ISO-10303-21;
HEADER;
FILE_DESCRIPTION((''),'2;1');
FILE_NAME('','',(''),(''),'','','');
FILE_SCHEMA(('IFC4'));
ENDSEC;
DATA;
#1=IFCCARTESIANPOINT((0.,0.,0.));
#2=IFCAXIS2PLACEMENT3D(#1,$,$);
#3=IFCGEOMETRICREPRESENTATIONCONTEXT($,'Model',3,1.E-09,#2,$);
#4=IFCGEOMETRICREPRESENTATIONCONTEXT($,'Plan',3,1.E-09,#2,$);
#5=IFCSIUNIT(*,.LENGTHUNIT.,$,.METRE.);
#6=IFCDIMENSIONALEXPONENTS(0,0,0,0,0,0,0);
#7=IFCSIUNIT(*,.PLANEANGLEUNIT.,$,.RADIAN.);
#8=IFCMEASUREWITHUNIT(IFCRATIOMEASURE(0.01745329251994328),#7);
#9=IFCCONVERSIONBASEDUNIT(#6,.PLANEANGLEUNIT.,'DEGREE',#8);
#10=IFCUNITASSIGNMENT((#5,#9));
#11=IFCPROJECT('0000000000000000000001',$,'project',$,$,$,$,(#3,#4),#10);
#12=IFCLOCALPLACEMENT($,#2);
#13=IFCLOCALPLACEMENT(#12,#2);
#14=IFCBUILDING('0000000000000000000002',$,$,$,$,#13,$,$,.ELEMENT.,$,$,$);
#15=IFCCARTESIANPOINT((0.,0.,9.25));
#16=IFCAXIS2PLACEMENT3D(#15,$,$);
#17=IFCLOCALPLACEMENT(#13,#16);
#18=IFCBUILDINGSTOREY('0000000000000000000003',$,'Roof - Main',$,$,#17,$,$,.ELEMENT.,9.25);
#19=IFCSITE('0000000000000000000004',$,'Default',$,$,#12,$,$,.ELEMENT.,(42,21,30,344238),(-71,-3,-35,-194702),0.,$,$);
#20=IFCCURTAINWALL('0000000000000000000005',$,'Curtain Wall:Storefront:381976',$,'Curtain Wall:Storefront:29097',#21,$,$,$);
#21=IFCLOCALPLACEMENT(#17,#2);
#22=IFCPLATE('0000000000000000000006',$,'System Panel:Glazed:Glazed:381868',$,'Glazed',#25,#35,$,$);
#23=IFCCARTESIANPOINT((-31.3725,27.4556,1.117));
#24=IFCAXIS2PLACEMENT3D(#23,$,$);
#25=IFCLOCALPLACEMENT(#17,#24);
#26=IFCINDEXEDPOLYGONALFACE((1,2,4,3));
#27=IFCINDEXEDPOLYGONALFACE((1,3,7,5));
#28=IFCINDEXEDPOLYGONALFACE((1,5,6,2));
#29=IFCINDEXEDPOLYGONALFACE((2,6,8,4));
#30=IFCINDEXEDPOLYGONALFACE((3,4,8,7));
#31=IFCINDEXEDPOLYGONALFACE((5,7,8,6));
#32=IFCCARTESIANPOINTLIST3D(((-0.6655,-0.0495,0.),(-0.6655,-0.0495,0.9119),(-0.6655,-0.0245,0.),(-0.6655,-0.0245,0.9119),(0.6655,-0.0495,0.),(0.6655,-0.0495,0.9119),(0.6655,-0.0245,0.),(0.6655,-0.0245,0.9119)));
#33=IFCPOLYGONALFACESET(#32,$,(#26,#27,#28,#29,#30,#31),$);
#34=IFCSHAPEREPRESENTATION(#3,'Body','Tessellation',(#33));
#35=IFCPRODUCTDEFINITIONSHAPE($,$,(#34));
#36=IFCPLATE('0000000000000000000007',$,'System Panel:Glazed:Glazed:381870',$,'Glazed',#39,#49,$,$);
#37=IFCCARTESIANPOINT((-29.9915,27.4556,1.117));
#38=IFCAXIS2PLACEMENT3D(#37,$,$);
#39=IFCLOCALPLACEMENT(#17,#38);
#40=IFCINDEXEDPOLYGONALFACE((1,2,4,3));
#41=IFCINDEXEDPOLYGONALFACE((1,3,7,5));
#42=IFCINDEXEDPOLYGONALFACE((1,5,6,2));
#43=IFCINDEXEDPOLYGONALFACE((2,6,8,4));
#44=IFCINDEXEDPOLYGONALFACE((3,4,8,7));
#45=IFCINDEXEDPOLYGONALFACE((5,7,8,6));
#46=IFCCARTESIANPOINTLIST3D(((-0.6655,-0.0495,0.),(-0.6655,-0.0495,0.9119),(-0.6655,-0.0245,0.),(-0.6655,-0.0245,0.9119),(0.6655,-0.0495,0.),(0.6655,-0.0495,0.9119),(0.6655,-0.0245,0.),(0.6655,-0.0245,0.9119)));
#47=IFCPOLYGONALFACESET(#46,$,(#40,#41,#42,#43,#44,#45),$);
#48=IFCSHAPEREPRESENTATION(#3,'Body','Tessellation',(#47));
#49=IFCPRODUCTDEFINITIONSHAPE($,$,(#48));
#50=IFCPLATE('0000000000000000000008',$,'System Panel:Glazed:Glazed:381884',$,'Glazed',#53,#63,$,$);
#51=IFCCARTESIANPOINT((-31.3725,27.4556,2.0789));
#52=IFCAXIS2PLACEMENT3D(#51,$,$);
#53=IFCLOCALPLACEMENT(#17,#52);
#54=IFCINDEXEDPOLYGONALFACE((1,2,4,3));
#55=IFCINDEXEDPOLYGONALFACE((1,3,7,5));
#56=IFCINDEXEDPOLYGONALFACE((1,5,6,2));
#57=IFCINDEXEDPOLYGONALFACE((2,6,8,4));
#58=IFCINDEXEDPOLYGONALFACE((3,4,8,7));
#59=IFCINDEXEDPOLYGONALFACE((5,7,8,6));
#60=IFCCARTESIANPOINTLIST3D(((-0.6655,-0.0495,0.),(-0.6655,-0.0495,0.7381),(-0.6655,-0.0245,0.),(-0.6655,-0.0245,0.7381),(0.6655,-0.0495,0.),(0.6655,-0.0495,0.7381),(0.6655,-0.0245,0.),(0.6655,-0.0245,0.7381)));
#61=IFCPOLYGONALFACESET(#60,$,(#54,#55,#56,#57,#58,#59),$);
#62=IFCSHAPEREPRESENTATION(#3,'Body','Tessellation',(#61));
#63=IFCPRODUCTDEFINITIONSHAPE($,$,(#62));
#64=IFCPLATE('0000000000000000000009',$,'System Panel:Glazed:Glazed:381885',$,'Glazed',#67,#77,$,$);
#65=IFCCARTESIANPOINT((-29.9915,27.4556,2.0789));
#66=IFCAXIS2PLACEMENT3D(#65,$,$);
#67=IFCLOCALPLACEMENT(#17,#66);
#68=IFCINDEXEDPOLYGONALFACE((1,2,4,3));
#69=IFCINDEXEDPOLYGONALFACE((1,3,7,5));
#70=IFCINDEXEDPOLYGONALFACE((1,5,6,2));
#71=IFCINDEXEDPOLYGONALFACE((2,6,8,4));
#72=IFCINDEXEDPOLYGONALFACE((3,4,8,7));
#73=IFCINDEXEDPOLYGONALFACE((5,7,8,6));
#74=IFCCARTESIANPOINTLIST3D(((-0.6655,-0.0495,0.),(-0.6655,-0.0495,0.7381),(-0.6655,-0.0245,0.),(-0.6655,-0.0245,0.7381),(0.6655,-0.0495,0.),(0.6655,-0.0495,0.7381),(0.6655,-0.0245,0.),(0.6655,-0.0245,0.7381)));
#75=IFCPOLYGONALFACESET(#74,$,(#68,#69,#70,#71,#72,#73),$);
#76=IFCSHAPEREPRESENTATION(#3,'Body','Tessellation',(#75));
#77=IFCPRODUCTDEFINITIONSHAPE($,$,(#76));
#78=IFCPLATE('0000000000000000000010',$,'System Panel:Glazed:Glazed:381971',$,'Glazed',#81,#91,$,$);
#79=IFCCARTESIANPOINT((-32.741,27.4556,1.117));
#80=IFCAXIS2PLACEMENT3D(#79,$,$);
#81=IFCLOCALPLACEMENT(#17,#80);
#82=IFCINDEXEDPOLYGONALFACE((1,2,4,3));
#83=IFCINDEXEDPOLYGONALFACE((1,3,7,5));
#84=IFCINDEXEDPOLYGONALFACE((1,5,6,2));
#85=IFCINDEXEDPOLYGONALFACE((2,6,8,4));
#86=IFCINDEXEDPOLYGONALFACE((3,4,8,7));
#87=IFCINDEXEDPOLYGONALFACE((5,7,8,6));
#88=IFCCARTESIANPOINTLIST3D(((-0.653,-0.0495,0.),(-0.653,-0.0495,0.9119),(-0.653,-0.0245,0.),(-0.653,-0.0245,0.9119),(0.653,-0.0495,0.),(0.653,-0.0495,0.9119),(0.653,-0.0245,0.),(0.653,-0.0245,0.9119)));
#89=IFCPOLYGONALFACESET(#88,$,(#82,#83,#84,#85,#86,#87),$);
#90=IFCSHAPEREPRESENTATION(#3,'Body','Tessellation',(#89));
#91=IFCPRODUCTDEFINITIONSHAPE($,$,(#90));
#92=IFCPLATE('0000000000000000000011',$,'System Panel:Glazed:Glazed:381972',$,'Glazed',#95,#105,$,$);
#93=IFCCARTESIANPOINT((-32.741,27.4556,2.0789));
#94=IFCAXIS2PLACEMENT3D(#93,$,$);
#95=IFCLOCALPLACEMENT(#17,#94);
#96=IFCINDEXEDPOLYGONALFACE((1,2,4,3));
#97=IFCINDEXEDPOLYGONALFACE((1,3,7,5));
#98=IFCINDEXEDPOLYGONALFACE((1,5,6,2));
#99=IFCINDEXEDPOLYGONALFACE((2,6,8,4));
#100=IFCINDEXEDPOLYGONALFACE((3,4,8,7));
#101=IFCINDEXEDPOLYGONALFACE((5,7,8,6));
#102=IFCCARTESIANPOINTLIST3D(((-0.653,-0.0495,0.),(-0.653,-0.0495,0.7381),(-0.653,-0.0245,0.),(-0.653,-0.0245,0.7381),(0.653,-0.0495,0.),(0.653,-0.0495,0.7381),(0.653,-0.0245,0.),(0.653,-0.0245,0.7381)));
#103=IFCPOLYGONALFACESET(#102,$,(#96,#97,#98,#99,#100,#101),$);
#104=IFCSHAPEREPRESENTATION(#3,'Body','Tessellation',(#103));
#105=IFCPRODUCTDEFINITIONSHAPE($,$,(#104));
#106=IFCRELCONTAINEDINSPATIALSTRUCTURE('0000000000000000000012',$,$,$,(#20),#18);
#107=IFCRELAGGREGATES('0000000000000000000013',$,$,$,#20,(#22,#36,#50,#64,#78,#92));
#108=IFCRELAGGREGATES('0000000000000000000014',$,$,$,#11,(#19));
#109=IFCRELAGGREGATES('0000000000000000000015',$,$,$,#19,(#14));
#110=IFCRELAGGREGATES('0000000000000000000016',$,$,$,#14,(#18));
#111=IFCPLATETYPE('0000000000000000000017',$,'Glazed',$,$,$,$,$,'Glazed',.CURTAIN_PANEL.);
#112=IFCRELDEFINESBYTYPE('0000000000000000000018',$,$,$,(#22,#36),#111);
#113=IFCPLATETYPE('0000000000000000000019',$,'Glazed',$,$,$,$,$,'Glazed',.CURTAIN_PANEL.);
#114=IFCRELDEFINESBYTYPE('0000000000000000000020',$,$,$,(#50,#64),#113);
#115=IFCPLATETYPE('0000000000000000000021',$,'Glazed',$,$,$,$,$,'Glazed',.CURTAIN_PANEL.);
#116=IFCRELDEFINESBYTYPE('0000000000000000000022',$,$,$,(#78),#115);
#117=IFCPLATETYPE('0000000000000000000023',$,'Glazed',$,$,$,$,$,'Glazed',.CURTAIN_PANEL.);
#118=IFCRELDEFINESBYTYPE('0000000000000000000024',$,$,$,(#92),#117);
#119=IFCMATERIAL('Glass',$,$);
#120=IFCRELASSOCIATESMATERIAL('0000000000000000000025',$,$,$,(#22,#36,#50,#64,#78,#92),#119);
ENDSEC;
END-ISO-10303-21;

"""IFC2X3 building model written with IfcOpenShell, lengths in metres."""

from ifc_helpers import new_model, entity, si_unit, converted_unit, frame, origin, origin_2d_with_axis, place, context, project, spatial, rectangle, extrude, source, transform, mapped, material, type_object, type_shapes, element, aggregate, save


model = new_model("IFC2X3")

# Units and contexts
model_context = context("Model", 3, precision=1e-09, world=origin())
plan_context = context("Plan", 3, precision=1e-09, world=origin())
ifc_project = project(units=[si_unit("LENGTHUNIT", "METRE"), converted_unit("PLANEANGLEUNIT", "DEGREE", entity("IfcRatioMeasure", 0.01745329251994328), si_unit("PLANEANGLEUNIT", "RADIAN"), dimensions=[0, 0, 0, 0, 0, 0, 0])], contexts=[model_context, plan_context])

# Site, building, storey
site_placement = place(None, origin())
site = spatial("IfcSite", under=ifc_project, at=site_placement, Name="Default", CompositionType="ELEMENT", RefLatitude=(42, 21, 30, 344238), RefLongitude=(-71, -3, -35, -194702), RefElevation=0.0)
building_placement = place(site_placement, origin())
building = spatial("IfcBuilding", under=site, at=building_placement, CompositionType="ELEMENT")
storey_placement = place(building_placement, frame((0.0, 0.0, 9.25)))
storey = spatial("IfcBuildingStorey", under=building, at=storey_placement, Name="Roof - Main", CompositionType="ELEMENT", Elevation=9.25)

# Curtain wall
curtain_wall_1_placement = place(storey_placement, origin())
curtain_wall_1 = element("IfcCurtainWall", 1, at=curtain_wall_1_placement, inside=storey, Name="Curtain Wall:Storefront:381976", ObjectType="Curtain Wall:Storefront:29097")

# Plates
ifc_material_1 = material(Name="Glass")
plate_type_1 = type_object("IfcPlateType", Name="Glazed", ElementType="Glazed", PredefinedType="CURTAIN_PANEL")
shared_shape_1 = source(origin(), model_context, "Body", "SweptSolid", [
    extrude(rectangle(XDim=0.025, YDim=1.331, at=origin_2d_with_axis()), frame((0.0, -0.037, 0.0), z_axis=(0.0, 0.0, 1.0), x_axis=(0.0, 1.0, 0.0)), (0.0, 0.0, 1.0), 0.9119),
])
type_shapes(plate_type_1, [shared_shape_1])
plate_1_placement = place(storey_placement, frame((-31.3725, 27.4556, 1.117)))
plate_1 = element("IfcPlate", 2, at=plate_1_placement, type_object=plate_type_1, material=ifc_material_1, Name="System Panel:Glazed:Glazed:381868", ObjectType="Glazed", context=model_context, shape_type="MappedRepresentation", body=[
    mapped(shared_shape_1, transform((0.0, 0.0, 0.0), scale=1.0)),
])
plate_2_placement = place(storey_placement, frame((-29.9915, 27.4556, 1.117)))
plate_2 = element("IfcPlate", 3, at=plate_2_placement, type_object=plate_type_1, material=ifc_material_1, Name="System Panel:Glazed:Glazed:381870", ObjectType="Glazed", context=model_context, shape_type="MappedRepresentation", body=[
    mapped(shared_shape_1, transform((0.0, 0.0, 0.0), scale=1.0)),
])
plate_type_2 = type_object("IfcPlateType", Name="Glazed", ElementType="Glazed", PredefinedType="CURTAIN_PANEL")
shared_shape_2 = source(origin(), model_context, "Body", "SweptSolid", [
    extrude(rectangle(XDim=0.025, YDim=1.331, at=origin_2d_with_axis()), frame((0.0, -0.037, 0.0), z_axis=(0.0, 0.0, 1.0), x_axis=(0.0, 1.0, 0.0)), (0.0, 0.0, 1.0), 0.7381),
])
type_shapes(plate_type_2, [shared_shape_2])
plate_3_placement = place(storey_placement, frame((-31.3725, 27.4556, 2.0789)))
plate_3 = element("IfcPlate", 4, at=plate_3_placement, type_object=plate_type_2, material=ifc_material_1, Name="System Panel:Glazed:Glazed:381884", ObjectType="Glazed", context=model_context, shape_type="MappedRepresentation", body=[
    mapped(shared_shape_2, transform((0.0, 0.0, 0.0), scale=1.0)),
])
plate_4_placement = place(storey_placement, frame((-29.9915, 27.4556, 2.0789)))
plate_4 = element("IfcPlate", 5, at=plate_4_placement, type_object=plate_type_2, material=ifc_material_1, Name="System Panel:Glazed:Glazed:381885", ObjectType="Glazed", context=model_context, shape_type="MappedRepresentation", body=[
    mapped(shared_shape_2, transform((0.0, 0.0, 0.0), scale=1.0)),
])
plate_type_3 = type_object("IfcPlateType", Name="Glazed", ElementType="Glazed", PredefinedType="CURTAIN_PANEL")
shared_shape_3 = source(origin(), model_context, "Body", "SweptSolid", [
    extrude(rectangle(XDim=0.025, YDim=1.306, at=origin_2d_with_axis()), frame((0.0, -0.037, 0.0), z_axis=(0.0, 0.0, 1.0), x_axis=(0.0, 1.0, 0.0)), (0.0, 0.0, 1.0), 0.9119),
])
type_shapes(plate_type_3, [shared_shape_3])
plate_5_placement = place(storey_placement, frame((-32.741, 27.4556, 1.117)))
plate_5 = element("IfcPlate", 6, at=plate_5_placement, type_object=plate_type_3, material=ifc_material_1, Name="System Panel:Glazed:Glazed:381971", ObjectType="Glazed", context=model_context, shape_type="MappedRepresentation", body=[
    mapped(shared_shape_3, transform((0.0, 0.0, 0.0), scale=1.0)),
])
plate_type_4 = type_object("IfcPlateType", Name="Glazed", ElementType="Glazed", PredefinedType="CURTAIN_PANEL")
shared_shape_4 = source(origin(), model_context, "Body", "SweptSolid", [
    extrude(rectangle(XDim=0.025, YDim=1.306, at=origin_2d_with_axis()), frame((0.0, -0.037, 0.0), z_axis=(0.0, 0.0, 1.0), x_axis=(0.0, 1.0, 0.0)), (0.0, 0.0, 1.0), 0.7381),
])
type_shapes(plate_type_4, [shared_shape_4])
plate_6_placement = place(storey_placement, frame((-32.741, 27.4556, 2.0789)))
plate_6 = element("IfcPlate", 7, at=plate_6_placement, type_object=plate_type_4, material=ifc_material_1, Name="System Panel:Glazed:Glazed:381972", ObjectType="Glazed", context=model_context, shape_type="MappedRepresentation", body=[
    mapped(shared_shape_4, transform((0.0, 0.0, 0.0), scale=1.0)),
])
aggregate(curtain_wall_1, [plate_1, plate_2, plate_3, plate_4, plate_5, plate_6])

save(model, "model.ifc")
